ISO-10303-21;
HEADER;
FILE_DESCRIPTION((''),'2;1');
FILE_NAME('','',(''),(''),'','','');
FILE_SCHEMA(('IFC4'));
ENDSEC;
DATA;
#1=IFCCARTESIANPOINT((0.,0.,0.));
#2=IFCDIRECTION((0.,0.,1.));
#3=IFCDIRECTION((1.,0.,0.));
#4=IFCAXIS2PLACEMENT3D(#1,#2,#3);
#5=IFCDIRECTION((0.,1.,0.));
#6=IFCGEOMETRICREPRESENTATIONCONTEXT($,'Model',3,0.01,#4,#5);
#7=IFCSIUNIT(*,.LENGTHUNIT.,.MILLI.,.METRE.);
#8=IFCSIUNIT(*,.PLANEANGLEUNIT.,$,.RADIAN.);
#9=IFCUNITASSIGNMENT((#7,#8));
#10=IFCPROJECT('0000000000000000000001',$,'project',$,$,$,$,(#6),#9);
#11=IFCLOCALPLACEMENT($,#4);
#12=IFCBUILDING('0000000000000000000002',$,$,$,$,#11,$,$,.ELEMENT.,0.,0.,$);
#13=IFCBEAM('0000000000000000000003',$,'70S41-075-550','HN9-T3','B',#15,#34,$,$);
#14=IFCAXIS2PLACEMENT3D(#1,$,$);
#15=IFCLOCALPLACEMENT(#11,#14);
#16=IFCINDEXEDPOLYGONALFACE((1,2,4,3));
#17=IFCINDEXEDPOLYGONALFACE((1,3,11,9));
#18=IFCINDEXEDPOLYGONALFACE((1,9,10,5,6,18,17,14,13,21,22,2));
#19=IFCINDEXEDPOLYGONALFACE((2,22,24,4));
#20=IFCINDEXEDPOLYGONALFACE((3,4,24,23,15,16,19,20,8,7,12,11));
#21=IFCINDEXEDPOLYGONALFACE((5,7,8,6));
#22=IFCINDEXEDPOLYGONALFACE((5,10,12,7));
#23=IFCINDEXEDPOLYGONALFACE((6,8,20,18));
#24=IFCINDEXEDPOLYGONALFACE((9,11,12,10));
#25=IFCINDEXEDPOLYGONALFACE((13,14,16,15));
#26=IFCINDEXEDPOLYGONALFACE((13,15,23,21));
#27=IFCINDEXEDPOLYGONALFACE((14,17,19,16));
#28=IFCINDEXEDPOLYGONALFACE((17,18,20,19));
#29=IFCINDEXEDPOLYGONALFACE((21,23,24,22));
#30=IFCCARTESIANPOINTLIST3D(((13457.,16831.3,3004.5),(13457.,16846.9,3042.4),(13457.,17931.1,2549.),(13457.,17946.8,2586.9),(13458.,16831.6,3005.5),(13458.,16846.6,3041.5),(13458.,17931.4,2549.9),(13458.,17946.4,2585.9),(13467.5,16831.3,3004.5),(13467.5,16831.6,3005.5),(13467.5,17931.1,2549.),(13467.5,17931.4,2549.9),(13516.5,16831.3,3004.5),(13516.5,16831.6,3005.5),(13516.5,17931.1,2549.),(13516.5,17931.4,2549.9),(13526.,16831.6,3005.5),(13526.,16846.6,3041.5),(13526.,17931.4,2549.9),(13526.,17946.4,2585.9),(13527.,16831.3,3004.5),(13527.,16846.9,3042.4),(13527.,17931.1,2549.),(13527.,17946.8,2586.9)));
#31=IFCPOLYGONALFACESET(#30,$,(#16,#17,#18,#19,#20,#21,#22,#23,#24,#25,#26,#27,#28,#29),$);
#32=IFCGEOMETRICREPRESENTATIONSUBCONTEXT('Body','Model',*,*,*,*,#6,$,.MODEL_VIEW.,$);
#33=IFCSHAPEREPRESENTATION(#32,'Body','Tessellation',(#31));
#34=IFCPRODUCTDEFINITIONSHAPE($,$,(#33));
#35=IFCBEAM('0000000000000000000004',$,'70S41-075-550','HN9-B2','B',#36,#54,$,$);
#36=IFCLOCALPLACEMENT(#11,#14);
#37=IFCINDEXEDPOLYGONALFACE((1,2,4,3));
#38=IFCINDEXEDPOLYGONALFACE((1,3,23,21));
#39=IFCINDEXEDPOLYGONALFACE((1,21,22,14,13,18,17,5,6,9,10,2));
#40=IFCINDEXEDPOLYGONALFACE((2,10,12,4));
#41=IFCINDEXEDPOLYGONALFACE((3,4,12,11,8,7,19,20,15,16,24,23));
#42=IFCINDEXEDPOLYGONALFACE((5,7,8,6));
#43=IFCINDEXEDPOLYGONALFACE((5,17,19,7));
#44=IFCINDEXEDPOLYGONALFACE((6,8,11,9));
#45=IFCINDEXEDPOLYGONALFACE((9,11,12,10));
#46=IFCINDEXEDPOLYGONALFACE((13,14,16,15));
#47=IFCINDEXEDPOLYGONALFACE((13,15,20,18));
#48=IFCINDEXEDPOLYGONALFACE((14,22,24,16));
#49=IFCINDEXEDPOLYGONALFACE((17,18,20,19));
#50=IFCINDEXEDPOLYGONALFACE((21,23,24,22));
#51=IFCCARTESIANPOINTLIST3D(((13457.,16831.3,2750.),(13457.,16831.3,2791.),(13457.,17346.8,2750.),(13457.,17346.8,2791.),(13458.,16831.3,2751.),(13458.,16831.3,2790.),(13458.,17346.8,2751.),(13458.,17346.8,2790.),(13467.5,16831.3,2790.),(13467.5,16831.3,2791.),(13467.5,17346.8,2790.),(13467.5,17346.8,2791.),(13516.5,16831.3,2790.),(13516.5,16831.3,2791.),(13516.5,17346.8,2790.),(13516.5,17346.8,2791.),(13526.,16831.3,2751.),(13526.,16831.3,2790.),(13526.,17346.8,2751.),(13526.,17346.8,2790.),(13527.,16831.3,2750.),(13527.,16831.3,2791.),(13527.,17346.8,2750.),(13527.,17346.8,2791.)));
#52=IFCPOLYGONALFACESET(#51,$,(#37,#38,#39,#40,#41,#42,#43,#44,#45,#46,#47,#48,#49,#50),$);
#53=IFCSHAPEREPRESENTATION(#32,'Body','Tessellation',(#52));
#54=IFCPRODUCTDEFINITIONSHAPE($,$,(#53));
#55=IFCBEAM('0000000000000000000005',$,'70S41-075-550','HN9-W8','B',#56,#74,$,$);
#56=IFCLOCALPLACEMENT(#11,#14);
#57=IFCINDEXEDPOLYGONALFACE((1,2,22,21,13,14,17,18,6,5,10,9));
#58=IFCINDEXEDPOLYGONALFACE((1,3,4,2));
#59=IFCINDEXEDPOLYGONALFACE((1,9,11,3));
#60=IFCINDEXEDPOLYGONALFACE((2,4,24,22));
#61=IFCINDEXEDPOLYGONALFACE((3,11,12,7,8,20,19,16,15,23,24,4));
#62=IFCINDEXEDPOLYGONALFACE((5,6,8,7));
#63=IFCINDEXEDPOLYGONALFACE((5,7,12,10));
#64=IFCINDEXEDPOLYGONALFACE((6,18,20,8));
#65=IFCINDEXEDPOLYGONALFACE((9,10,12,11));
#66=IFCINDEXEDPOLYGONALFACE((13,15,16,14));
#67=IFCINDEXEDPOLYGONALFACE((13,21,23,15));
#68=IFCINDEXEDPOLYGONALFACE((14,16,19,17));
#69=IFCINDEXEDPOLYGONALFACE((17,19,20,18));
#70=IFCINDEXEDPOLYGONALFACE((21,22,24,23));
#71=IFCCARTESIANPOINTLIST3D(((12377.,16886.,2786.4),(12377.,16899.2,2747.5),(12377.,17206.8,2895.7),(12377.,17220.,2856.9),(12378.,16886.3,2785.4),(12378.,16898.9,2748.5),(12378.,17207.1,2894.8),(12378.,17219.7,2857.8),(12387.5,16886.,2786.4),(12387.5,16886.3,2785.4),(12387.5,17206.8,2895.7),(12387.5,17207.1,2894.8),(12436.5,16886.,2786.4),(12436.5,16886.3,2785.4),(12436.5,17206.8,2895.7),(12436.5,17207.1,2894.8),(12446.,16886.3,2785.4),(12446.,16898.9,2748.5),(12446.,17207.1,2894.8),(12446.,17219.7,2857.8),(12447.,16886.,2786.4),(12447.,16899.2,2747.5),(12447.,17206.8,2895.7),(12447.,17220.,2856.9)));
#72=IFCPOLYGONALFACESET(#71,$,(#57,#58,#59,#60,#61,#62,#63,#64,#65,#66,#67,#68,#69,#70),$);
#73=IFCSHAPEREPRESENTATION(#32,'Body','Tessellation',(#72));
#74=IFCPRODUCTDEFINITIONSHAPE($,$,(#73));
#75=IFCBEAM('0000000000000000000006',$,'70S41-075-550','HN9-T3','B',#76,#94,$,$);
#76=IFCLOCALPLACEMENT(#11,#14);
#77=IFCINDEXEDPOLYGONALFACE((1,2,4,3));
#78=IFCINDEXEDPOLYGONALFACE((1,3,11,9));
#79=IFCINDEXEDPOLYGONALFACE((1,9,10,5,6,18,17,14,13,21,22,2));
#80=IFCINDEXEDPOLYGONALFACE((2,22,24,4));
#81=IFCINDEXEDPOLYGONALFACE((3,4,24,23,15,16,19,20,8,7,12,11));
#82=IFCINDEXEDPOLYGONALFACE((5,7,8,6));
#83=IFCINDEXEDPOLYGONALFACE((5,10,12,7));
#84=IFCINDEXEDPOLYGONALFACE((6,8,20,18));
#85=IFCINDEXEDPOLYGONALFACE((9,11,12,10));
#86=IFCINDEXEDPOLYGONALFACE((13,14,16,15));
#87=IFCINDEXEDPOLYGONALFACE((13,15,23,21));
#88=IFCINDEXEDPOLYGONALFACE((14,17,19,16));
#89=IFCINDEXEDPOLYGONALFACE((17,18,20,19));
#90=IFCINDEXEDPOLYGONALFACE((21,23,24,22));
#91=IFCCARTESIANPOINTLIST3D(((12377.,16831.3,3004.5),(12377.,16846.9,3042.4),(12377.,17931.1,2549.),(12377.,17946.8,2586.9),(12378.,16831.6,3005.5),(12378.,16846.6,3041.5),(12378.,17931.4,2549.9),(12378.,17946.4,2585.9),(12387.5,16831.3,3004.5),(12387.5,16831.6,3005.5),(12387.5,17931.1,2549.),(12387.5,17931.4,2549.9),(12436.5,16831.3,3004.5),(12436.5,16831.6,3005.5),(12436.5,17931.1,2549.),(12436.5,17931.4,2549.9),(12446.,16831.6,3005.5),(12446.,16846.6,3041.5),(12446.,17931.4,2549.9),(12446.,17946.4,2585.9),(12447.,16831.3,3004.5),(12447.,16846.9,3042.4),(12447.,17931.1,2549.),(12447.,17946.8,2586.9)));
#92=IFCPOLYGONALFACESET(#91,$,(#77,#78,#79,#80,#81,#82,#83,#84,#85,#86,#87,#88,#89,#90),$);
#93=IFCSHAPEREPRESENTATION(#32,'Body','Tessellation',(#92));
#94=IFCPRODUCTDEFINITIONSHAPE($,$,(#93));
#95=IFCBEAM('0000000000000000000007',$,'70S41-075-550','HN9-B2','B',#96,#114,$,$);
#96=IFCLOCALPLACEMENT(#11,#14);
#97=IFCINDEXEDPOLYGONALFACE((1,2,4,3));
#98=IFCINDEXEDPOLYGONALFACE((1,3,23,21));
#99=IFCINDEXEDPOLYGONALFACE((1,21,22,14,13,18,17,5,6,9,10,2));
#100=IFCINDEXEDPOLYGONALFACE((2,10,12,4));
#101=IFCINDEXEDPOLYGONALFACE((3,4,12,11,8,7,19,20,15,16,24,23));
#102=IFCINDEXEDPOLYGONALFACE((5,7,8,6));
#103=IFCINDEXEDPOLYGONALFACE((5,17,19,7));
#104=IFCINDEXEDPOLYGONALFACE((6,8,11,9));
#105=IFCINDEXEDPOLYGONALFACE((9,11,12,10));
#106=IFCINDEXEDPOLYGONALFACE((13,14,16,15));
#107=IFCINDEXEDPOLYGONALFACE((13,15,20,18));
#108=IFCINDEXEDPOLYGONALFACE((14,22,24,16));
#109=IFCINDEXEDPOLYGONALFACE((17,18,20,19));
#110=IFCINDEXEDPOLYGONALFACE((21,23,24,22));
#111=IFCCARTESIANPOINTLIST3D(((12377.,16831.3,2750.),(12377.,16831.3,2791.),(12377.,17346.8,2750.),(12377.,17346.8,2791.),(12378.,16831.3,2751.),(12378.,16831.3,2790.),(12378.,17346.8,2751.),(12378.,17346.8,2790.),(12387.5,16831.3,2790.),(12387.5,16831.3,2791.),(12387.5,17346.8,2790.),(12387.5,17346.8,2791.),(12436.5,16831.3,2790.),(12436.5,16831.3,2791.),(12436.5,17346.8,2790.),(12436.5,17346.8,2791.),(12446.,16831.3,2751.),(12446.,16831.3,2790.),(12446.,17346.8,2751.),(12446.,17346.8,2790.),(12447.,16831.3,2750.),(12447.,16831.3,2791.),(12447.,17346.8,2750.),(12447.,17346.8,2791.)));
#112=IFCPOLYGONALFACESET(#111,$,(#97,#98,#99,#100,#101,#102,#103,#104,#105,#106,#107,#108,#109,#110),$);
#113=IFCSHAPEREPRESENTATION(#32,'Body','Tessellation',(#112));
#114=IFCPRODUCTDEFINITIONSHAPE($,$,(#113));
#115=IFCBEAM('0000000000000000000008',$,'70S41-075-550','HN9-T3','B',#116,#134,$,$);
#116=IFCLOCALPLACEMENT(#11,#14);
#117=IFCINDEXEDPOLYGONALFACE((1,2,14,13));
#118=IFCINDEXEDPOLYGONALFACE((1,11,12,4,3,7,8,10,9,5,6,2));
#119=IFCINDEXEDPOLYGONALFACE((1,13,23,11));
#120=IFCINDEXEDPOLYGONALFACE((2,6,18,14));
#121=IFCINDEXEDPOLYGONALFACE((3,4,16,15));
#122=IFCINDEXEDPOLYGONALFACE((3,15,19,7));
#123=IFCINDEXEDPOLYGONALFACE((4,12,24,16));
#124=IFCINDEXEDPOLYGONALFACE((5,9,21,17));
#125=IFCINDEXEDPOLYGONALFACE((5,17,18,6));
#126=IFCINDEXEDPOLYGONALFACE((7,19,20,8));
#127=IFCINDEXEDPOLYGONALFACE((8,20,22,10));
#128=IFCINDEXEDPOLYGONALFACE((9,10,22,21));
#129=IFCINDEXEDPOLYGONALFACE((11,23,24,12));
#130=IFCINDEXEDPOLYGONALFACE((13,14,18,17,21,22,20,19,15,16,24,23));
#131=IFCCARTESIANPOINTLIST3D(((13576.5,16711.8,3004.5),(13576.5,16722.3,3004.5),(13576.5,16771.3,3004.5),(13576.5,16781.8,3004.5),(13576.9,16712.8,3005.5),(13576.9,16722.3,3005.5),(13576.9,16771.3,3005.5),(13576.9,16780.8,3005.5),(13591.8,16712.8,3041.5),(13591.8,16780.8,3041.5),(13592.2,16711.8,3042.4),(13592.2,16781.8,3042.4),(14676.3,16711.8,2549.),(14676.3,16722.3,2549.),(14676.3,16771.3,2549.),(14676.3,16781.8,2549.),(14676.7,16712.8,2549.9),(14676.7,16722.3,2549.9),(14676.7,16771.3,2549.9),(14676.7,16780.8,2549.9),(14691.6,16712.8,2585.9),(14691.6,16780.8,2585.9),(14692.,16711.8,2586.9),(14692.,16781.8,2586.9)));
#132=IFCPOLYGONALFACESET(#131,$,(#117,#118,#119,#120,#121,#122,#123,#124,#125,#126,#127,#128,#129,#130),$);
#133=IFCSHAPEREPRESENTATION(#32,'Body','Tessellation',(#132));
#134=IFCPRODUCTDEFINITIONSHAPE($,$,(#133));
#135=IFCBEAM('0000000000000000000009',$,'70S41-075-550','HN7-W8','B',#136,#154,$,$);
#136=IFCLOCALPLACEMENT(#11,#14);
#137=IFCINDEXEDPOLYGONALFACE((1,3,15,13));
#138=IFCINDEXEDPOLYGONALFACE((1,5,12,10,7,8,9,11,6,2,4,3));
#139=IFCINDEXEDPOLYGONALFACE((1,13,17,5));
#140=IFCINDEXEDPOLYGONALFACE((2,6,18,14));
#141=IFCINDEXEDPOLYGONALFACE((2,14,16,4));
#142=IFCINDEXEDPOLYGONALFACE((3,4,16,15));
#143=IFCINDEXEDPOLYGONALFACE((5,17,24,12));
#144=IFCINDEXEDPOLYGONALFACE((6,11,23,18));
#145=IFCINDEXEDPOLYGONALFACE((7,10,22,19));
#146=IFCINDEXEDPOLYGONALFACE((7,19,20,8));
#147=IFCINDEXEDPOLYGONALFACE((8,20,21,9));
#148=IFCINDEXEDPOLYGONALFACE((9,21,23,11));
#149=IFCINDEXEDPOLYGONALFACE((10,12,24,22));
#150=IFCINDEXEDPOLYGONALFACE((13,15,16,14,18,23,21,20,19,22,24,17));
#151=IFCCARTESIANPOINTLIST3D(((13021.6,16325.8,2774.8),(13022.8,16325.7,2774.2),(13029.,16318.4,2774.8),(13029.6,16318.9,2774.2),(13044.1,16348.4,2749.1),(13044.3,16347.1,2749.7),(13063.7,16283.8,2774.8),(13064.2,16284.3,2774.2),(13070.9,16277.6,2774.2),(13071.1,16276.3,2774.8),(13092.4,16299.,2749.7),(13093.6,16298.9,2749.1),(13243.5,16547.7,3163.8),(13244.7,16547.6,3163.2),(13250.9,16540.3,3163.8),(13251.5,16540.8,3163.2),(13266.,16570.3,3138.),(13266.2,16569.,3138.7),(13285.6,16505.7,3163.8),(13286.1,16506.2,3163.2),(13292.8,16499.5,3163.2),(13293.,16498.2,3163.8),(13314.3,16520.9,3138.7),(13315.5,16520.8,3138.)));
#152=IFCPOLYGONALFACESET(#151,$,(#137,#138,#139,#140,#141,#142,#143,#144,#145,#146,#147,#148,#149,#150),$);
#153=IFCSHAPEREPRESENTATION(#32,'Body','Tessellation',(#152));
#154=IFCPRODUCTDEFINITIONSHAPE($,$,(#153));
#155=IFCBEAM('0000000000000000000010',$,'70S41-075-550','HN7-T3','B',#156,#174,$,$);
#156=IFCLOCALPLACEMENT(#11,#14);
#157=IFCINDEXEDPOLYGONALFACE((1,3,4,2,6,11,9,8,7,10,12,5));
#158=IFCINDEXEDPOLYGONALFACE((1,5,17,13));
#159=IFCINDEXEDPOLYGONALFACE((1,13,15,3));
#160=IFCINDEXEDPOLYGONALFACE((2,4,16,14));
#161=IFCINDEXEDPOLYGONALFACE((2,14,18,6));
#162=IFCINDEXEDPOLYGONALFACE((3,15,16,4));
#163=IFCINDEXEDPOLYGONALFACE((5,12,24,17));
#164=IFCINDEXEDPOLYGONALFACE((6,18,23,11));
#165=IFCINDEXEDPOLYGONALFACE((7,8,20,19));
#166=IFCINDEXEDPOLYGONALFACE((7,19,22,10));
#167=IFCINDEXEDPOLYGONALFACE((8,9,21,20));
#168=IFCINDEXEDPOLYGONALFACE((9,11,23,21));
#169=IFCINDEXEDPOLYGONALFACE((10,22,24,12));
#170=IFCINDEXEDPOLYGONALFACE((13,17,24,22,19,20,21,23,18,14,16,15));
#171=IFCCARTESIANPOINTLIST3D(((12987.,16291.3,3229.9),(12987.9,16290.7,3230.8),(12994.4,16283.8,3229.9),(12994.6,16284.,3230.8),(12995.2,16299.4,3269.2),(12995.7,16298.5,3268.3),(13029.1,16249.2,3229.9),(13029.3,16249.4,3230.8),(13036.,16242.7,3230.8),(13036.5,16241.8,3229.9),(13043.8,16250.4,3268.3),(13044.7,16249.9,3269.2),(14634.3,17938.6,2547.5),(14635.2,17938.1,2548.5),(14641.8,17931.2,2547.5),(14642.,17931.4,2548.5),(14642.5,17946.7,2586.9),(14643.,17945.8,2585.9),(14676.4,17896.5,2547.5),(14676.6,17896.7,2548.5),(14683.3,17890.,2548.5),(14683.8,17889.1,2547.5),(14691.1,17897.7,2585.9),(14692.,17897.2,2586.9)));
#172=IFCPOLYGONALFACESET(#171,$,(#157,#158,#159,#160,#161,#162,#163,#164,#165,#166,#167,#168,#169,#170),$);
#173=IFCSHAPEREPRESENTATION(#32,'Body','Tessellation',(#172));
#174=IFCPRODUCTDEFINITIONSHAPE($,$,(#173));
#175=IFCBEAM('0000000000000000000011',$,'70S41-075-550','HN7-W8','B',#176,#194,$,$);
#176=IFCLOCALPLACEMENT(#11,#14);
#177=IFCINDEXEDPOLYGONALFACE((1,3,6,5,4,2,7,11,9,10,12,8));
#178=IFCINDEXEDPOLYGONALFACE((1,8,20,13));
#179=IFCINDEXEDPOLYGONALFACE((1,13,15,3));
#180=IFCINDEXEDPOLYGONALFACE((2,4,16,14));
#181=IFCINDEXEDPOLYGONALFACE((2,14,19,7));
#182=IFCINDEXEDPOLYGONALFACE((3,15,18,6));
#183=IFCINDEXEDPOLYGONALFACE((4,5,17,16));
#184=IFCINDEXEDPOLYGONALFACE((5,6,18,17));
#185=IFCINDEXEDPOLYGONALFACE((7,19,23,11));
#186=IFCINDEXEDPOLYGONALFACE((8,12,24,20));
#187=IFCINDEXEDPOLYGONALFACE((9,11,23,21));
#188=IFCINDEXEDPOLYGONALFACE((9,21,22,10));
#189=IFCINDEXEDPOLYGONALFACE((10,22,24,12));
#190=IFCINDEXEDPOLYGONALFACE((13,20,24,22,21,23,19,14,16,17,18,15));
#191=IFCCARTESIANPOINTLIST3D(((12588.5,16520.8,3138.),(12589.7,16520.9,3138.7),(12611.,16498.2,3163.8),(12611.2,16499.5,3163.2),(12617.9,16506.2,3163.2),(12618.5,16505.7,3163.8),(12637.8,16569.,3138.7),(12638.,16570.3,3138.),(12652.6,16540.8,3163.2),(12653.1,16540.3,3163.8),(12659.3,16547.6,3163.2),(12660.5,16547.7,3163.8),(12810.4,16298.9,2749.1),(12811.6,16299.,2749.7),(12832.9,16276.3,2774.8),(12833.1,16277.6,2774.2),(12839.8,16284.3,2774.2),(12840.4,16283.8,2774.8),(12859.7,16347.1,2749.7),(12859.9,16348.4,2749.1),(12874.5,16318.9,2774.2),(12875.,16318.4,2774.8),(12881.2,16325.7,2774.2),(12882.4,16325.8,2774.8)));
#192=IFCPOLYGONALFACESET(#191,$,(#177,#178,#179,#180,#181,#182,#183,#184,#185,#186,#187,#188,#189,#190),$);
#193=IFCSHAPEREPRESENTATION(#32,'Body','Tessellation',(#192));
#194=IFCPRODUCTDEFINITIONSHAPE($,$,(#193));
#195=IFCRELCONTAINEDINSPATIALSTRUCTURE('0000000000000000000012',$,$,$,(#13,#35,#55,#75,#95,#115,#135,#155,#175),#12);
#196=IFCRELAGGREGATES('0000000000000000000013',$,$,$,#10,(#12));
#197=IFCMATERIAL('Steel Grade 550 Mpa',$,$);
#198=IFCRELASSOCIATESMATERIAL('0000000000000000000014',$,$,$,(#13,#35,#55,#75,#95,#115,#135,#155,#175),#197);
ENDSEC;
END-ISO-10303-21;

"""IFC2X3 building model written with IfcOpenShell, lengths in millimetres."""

from ifc_helpers import new_model, si_unit, direction, frame, origin, origin_with_axes, origin_2d_with_axis, place, context, subcontext, project, spatial, c_section, extrude, source, transform, mapped, material, element, save


model = new_model("IFC2X3")

# Units and contexts
model_context = context("Model", 3, precision=0.01, world=origin_with_axes(), true_north=direction((0.0, 1.0, 0.0)))
body_context = subcontext(model_context, "Body", "Model", "MODEL_VIEW")
ifc_project = project(units=[si_unit("LENGTHUNIT", "METRE", prefix="MILLI"), si_unit("PLANEANGLEUNIT", "RADIAN")], contexts=[model_context])

# Building
building_placement = place(None, origin_with_axes())
building = spatial("IfcBuilding", under=ifc_project, at=building_placement, CompositionType="ELEMENT", ElevationOfRefHeight=0.0, ElevationOfTerrain=0.0)

# Shared definitions
ifc_material = material(Name="Steel Grade 550 Mpa")

# Beams
shared_shape_1 = source(origin(), body_context, "Body", "SweptSolid", [
    extrude(c_section(Depth=70.0, Width=41.0, WallThickness=1.0, Girth=10.5, at=origin_2d_with_axis()), origin_with_axes(), (0.0, 0.0, 1.0), 1190.4),
])
beam_1_placement = place(None, frame((13492.0, 16839.1, 3023.5), z_axis=(0.0, 0.92388, -0.382683), x_axis=(0.0, -0.382683, -0.92388)))
element("IfcBeam", 1, at=beam_1_placement, inside=building, material=ifc_material, Name="70S41-075-550", Description="HN9-T3", ObjectType="B", context=body_context, shape_type="MappedRepresentation", body=[
    mapped(shared_shape_1, transform((0.0, 0.0, 0.0), scale=1.0)),
])
shared_shape_2 = source(origin(), body_context, "Body", "SweptSolid", [
    extrude(c_section(Depth=70.0, Width=41.0, WallThickness=1.0, Girth=10.5, at=origin_2d_with_axis()), origin_with_axes(), (0.0, 0.0, 1.0), 515.5),
])
beam_2_placement = place(None, frame((13492.0, 17346.8, 2770.5), z_axis=(0.0, -1.0, 0.0), x_axis=(0.0, 0.0, 1.0)))
element("IfcBeam", 2, at=beam_2_placement, inside=building, material=ifc_material, Name="70S41-075-550", Description="HN9-B2", ObjectType="B", context=body_context, shape_type="MappedRepresentation", body=[
    mapped(shared_shape_2, transform((0.0, 0.0, 0.0), scale=1.0)),
])
shared_shape_3 = source(origin(), body_context, "Body", "SweptSolid", [
    extrude(c_section(Depth=70.0, Width=41.0, WallThickness=1.0, Girth=10.5, at=origin_2d_with_axis()), origin_with_axes(), (0.0, 0.0, 1.0), 338.9),
])
beam_3_placement = place(None, frame((12412.0, 17213.4, 2876.3), z_axis=(0.0, -0.946528, -0.322621), x_axis=(0.0, -0.322621, 0.946528)))
element("IfcBeam", 3, at=beam_3_placement, inside=building, material=ifc_material, Name="70S41-075-550", Description="HN9-W8", ObjectType="B", context=body_context, shape_type="MappedRepresentation", body=[
    mapped(shared_shape_3, transform((0.0, 0.0, 0.0), scale=1.0)),
])
shared_shape_4 = source(origin(), body_context, "Body", "SweptSolid", [
    extrude(c_section(Depth=70.0, Width=41.0, WallThickness=1.0, Girth=10.5, at=origin_2d_with_axis()), origin_with_axes(), (0.0, 0.0, 1.0), 1190.4),
])
beam_4_placement = place(None, frame((12412.0, 16839.1, 3023.5), z_axis=(0.0, 0.92388, -0.382683), x_axis=(0.0, -0.382683, -0.92388)))
element("IfcBeam", 4, at=beam_4_placement, inside=building, material=ifc_material, Name="70S41-075-550", Description="HN9-T3", ObjectType="B", context=body_context, shape_type="MappedRepresentation", body=[
    mapped(shared_shape_4, transform((0.0, 0.0, 0.0), scale=1.0)),
])
shared_shape_5 = source(origin(), body_context, "Body", "SweptSolid", [
    extrude(c_section(Depth=70.0, Width=41.0, WallThickness=1.0, Girth=10.5, at=origin_2d_with_axis()), origin_with_axes(), (0.0, 0.0, 1.0), 515.5),
])
beam_5_placement = place(None, frame((12412.0, 17346.8, 2770.5), z_axis=(0.0, -1.0, 0.0), x_axis=(0.0, 0.0, 1.0)))
element("IfcBeam", 5, at=beam_5_placement, inside=building, material=ifc_material, Name="70S41-075-550", Description="HN9-B2", ObjectType="B", context=body_context, shape_type="MappedRepresentation", body=[
    mapped(shared_shape_5, transform((0.0, 0.0, 0.0), scale=1.0)),
])
shared_shape_6 = source(origin(), body_context, "Body", "SweptSolid", [
    extrude(c_section(Depth=70.0, Width=41.0, WallThickness=1.0, Girth=10.5, at=origin_2d_with_axis()), origin_with_axes(), (0.0, 0.0, 1.0), 1190.4),
])
beam_6_placement = place(None, frame((13584.4, 16746.8, 3023.5), z_axis=(0.92388, 0.0, -0.382683), x_axis=(-0.382683, 0.0, -0.92388)))
element("IfcBeam", 6, at=beam_6_placement, inside=building, material=ifc_material, Name="70S41-075-550", Description="HN9-T3", ObjectType="B", context=body_context, shape_type="MappedRepresentation", body=[
    mapped(shared_shape_6, transform((0.0, 0.0, 0.0), scale=1.0)),
])
shared_shape_7 = source(origin(), body_context, "Body", "SweptSolid", [
    extrude(c_section(Depth=70.0, Width=41.0, WallThickness=1.0, Girth=10.5, at=origin_2d_with_axis()), origin_with_axes(), (0.0, 0.0, 1.0), 499.8),
])
beam_7_placement = place(None, frame((13279.5, 16534.3, 3150.9), z_axis=(-0.44399, -0.44399, -0.778296), x_axis=(-0.550339, -0.550339, 0.627897)))
element("IfcBeam", 7, at=beam_7_placement, inside=building, material=ifc_material, Name="70S41-075-550", Description="HN7-W8", ObjectType="B", context=body_context, shape_type="MappedRepresentation", body=[
    mapped(shared_shape_7, transform((0.0, 0.0, 0.0), scale=1.0)),
])
shared_shape_8 = source(origin(), body_context, "Body", "SweptSolid", [
    extrude(c_section(Depth=70.0, Width=41.0, WallThickness=1.0, Girth=10.5, at=origin_2d_with_axis()), origin_with_axes(), (0.0, 0.0, 1.0), 2427.5),
])
beam_8_placement = place(None, frame((13015.8, 16270.6, 3249.6), z_axis=(0.678598, 0.678598, -0.281085), x_axis=(-0.198757, -0.198757, -0.959683)))
element("IfcBeam", 8, at=beam_8_placement, inside=building, material=ifc_material, Name="70S41-075-550", Description="HN7-T3", ObjectType="B", context=body_context, shape_type="MappedRepresentation", body=[
    mapped(shared_shape_8, transform((0.0, 0.0, 0.0), scale=1.0)),
])
shared_shape_9 = source(origin(), body_context, "Body", "SweptSolid", [
    extrude(c_section(Depth=70.0, Width=41.0, WallThickness=1.0, Girth=10.5, at=origin_2d_with_axis()), origin_with_axes(), (0.0, 0.0, 1.0), 499.8),
])
beam_9_placement = place(None, frame((12624.5, 16534.3, 3150.9), z_axis=(0.44399, -0.44399, -0.778296), x_axis=(0.550339, -0.550339, 0.627897)))
element("IfcBeam", 9, at=beam_9_placement, inside=building, material=ifc_material, Name="70S41-075-550", Description="HN7-W8", ObjectType="B", context=body_context, shape_type="MappedRepresentation", body=[
    mapped(shared_shape_9, transform((0.0, 0.0, 0.0), scale=1.0)),
])

save(model, "model.ifc")
